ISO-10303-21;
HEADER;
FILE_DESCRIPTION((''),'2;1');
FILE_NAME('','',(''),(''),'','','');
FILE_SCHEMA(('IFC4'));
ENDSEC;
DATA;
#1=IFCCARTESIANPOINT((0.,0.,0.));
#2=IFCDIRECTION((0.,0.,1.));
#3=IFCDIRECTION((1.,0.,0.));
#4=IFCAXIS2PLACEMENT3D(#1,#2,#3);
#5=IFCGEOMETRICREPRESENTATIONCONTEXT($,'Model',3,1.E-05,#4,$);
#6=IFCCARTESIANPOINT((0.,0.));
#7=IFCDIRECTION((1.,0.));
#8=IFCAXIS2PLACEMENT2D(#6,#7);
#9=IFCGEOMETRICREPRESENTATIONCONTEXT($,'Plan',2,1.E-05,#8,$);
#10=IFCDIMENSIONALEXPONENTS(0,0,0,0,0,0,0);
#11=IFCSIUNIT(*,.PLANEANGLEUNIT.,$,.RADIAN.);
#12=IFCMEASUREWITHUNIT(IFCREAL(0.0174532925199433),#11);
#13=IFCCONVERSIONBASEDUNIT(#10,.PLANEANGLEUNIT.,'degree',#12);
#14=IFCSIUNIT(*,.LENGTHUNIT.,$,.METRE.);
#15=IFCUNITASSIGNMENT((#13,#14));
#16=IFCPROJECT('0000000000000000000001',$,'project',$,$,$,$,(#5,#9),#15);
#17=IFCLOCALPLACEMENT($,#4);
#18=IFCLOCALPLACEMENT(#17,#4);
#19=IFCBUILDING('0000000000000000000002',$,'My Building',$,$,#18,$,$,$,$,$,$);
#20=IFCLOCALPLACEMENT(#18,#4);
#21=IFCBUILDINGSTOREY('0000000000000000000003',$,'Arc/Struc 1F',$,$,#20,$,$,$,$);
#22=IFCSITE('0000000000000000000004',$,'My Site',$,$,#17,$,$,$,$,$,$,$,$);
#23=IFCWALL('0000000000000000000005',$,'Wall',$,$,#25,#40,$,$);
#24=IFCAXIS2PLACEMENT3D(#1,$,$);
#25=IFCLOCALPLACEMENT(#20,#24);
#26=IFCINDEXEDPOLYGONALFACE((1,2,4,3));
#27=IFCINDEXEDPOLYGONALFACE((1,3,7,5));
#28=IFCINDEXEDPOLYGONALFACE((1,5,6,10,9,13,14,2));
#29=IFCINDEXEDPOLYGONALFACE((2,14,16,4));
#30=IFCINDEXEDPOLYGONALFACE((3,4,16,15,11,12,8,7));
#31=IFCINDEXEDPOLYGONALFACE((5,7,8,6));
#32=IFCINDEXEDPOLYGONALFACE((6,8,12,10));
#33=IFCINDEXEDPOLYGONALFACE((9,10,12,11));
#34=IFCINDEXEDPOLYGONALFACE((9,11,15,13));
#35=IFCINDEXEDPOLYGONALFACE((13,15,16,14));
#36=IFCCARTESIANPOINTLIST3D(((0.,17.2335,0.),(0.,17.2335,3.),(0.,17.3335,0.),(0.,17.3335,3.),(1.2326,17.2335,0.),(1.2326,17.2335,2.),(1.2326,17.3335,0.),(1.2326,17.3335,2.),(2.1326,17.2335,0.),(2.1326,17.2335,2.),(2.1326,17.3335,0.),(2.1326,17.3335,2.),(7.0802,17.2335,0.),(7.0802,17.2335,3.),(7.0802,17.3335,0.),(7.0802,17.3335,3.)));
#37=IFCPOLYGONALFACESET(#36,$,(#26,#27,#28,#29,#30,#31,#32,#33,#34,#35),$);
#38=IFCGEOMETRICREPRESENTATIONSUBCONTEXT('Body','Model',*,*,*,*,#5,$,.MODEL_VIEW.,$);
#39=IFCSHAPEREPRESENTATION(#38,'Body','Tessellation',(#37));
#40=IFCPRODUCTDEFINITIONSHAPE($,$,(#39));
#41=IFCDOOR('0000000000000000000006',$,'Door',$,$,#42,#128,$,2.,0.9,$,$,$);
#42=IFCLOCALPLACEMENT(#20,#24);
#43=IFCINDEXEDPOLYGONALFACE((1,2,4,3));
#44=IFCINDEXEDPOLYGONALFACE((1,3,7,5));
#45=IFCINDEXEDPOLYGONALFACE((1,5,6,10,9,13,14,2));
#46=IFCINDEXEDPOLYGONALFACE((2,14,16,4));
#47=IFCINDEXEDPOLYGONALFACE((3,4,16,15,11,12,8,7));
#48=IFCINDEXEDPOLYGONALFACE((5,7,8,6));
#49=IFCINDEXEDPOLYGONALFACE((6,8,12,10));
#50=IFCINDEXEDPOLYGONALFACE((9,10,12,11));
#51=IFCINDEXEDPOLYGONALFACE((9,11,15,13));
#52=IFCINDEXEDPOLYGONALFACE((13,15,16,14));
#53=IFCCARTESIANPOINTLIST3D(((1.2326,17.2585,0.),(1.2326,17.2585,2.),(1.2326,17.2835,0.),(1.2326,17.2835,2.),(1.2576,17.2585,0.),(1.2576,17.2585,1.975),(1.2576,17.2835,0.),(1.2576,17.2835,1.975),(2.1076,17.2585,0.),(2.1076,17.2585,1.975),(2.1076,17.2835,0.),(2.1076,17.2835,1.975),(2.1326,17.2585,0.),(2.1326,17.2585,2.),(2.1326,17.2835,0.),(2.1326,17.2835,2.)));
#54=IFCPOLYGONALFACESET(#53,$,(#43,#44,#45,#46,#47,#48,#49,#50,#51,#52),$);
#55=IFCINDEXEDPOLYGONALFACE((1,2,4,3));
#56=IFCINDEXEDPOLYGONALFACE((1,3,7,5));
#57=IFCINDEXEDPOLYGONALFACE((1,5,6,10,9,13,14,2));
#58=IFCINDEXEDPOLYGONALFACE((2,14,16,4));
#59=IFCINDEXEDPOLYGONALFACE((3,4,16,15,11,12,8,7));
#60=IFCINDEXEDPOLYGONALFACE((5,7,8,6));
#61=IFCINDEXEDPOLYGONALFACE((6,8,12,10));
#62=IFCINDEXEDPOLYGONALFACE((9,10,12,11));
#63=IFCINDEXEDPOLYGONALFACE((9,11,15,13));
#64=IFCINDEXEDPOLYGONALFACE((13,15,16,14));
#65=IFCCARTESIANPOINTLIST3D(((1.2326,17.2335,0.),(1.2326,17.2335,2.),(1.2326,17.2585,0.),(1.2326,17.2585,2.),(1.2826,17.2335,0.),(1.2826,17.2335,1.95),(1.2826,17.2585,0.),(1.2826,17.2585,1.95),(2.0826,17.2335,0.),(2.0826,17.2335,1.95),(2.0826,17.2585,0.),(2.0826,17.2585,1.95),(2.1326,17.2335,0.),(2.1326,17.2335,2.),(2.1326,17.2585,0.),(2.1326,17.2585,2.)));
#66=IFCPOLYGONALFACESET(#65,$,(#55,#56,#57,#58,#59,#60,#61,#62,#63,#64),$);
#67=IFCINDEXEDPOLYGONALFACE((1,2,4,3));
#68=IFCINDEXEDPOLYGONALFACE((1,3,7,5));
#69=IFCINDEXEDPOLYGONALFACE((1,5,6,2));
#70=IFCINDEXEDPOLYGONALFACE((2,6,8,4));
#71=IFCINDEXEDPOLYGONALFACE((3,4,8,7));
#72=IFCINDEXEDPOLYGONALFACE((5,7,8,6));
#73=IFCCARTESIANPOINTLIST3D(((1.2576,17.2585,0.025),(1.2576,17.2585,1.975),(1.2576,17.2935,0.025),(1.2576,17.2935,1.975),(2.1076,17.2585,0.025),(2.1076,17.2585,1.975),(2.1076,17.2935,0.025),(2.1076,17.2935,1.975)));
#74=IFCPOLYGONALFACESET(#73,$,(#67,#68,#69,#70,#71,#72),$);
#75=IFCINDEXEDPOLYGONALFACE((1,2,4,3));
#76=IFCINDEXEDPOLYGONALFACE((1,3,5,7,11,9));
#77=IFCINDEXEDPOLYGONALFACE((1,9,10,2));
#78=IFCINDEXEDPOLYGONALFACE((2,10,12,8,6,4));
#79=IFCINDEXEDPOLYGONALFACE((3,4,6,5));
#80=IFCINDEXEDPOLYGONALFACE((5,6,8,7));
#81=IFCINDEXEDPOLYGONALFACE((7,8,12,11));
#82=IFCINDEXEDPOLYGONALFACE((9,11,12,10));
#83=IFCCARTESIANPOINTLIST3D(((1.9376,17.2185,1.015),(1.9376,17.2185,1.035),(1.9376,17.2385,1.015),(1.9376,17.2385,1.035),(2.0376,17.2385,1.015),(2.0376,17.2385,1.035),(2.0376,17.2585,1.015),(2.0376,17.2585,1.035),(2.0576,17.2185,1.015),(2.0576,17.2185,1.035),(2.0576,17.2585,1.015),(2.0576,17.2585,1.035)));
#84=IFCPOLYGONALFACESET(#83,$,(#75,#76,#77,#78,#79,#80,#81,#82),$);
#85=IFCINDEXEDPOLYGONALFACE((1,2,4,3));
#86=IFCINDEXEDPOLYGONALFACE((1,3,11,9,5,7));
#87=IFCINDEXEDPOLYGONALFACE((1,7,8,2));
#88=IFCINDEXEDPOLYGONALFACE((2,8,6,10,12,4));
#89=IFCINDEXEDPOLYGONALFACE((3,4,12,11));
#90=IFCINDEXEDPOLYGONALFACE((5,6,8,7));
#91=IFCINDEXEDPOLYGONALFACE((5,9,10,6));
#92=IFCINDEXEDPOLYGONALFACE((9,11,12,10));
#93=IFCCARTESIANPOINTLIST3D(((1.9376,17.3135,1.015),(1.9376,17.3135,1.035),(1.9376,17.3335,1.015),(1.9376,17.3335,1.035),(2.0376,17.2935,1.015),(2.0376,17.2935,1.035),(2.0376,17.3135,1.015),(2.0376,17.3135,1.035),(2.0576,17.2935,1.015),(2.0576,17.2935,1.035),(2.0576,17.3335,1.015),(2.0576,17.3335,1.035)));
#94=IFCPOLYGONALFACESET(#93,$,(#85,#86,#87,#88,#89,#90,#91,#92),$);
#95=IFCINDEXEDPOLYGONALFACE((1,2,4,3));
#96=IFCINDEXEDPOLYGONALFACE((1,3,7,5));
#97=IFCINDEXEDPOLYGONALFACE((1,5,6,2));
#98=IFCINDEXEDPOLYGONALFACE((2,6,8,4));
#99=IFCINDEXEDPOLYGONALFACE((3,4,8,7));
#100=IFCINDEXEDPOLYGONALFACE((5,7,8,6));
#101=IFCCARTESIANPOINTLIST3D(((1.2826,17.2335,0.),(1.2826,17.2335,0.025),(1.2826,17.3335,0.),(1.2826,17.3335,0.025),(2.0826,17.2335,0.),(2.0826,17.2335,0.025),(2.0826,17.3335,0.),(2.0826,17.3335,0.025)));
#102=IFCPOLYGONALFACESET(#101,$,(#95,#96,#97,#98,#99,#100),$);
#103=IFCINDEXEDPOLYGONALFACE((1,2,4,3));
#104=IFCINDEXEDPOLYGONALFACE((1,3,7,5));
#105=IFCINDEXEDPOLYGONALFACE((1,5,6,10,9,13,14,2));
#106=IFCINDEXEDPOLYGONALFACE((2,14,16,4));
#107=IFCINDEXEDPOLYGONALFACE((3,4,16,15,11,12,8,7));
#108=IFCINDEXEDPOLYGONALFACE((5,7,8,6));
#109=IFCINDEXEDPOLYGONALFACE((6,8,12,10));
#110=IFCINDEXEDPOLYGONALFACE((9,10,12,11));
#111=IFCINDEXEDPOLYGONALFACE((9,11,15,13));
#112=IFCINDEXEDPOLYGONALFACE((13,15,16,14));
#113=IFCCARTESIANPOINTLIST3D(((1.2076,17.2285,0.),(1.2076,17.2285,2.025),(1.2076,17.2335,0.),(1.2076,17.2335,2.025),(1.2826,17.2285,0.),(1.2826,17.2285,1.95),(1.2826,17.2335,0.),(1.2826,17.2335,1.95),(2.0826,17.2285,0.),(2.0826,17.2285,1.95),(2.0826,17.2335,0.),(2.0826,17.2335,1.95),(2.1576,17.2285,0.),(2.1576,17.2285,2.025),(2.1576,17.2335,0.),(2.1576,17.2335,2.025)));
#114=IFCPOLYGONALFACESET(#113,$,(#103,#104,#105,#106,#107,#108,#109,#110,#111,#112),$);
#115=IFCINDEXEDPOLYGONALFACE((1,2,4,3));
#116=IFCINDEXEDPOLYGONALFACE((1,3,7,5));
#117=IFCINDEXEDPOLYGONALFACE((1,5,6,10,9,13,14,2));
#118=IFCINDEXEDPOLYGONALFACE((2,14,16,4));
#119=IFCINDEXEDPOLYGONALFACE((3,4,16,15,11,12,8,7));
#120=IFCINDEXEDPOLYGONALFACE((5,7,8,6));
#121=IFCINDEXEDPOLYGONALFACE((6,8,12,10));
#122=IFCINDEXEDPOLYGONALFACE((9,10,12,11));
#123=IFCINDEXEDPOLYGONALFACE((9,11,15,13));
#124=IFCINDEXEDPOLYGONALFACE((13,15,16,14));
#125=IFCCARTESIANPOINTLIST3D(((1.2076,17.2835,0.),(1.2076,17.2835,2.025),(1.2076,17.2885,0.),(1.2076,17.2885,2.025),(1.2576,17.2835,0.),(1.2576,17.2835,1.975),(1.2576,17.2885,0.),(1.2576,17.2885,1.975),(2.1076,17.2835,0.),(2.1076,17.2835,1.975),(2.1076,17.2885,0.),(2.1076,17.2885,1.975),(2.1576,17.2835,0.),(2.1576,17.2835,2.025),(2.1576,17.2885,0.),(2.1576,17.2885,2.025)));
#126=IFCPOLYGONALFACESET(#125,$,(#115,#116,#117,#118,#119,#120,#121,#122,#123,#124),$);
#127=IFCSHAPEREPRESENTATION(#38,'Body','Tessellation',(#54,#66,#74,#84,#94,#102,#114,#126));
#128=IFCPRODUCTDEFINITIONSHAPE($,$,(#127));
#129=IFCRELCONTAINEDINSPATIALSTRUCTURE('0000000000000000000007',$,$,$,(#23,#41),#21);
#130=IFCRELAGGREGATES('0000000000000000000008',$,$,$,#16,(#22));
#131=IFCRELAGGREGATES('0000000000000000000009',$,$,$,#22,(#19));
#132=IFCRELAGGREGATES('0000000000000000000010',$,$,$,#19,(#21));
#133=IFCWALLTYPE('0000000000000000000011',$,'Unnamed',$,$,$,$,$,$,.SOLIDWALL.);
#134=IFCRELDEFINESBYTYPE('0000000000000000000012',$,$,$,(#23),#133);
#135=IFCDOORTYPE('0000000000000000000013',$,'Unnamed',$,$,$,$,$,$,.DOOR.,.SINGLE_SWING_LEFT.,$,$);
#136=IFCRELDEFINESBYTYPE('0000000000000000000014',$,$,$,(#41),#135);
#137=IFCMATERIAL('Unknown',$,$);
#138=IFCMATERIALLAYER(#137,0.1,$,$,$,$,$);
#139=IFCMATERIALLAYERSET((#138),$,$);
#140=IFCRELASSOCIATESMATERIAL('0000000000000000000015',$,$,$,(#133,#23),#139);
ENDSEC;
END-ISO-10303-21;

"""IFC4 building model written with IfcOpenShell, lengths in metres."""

from ifc_helpers import new_model, entity, si_unit, converted_unit, frame, origin_with_axes, origin_2d_with_axis, place, context, subcontext, project, spatial, line, indexed_curve, outline, extrude, shape, source, transform, mapped, material, layer, layer_set, layer_usage, type_object, type_shapes, element, fill, save


model = new_model("IFC4")

# Units and contexts
model_context = context("Model", 3, precision=1e-05, world=origin_with_axes())
plan_context = context("Plan", 2, precision=1e-05, world=origin_2d_with_axis())
body_context_1 = subcontext(model_context, "Body", "Model", "MODEL_VIEW")
body_context_2 = subcontext(plan_context, "Body", "Plan", "PLAN_VIEW")
ifc_project = project(units=[converted_unit("PLANEANGLEUNIT", "degree", entity("IfcReal", 0.0174532925199433), si_unit("PLANEANGLEUNIT", "RADIAN"), dimensions=[0, 0, 0, 0, 0, 0, 0]), si_unit("LENGTHUNIT", "METRE")], contexts=[model_context, plan_context])

# Site, building, storey
site_placement = place(None, origin_with_axes())
site = spatial("IfcSite", under=ifc_project, at=site_placement, Name="My Site")
building_placement = place(site_placement, origin_with_axes())
building = spatial("IfcBuilding", under=site, at=building_placement, Name="My Building")
storey_placement = place(building_placement, origin_with_axes())
storey = spatial("IfcBuildingStorey", under=building, at=storey_placement, Name="Arc/Struc 1F")

# Shared definitions
ifc_material = material(Name="Unknown")

# Shared definitions
ifc_layer_1 = layer(ifc_material, 0.1)
ifc_layer_set_1 = layer_set([ifc_layer_1])
wall_type = type_object("IfcWallType", Name="Unnamed", PredefinedType="SOLIDWALL", material=ifc_layer_set_1)

# Shared definitions
shared_shape_1 = source(origin_with_axes(), body_context_1, "Body", "SweptSolid", [
    extrude(outline(indexed_curve([(0.0, 0.0), (0.9, 0.0), (0.9, 2.0), (0.0, 2.0)], segments=[line(1, 2, 3, 4, 1)])), frame((0.0, -0.6, 0.0), z_axis=(0.0, -1.0, 0.0), x_axis=(1.0, 0.0, 0.0)), (0.0, 0.0, -1.0), 1.2),
])
door_type = type_object("IfcDoorType", Name="Unnamed", OperationType="SINGLE_SWING_LEFT", PredefinedType="DOOR")
shared_shape_2 = source(origin_with_axes(), body_context_1, "Body", "SweptSolid", [
    extrude(outline(indexed_curve([(0.0, 0.0), (0.0, 2.0), (0.9, 2.0), (0.9, 0.0), (0.875, 0.0), (0.875, 1.975), (0.025, 1.975), (0.025, 0.0)], segments=[line(1, 2, 3, 4, 5, 6, 7, 8, 1)])), frame((0.0, 0.025, 0.0), z_axis=(0.0, -1.0, 0.0), x_axis=(1.0, 0.0, 0.0)), (0.0, 0.0, -1.0), 0.025),
    extrude(outline(indexed_curve([(0.0, 0.0), (0.0, 2.0), (0.9, 2.0), (0.9, 0.0), (0.85, 0.0), (0.85, 1.95), (0.05, 1.95), (0.05, 0.0)], segments=[line(1, 2, 3, 4, 5, 6, 7, 8, 1)])), frame((0.0, 0.0, 0.0), z_axis=(0.0, -1.0, 0.0), x_axis=(1.0, 0.0, 0.0)), (0.0, 0.0, -1.0), 0.025),
    extrude(outline(indexed_curve([(0.0, 0.0), (0.85, 0.0), (0.85, 0.035), (0.0, 0.035)], segments=[line(1, 2, 3, 4, 1)])), frame((0.025, 0.025, 0.025), z_axis=(0.0, 0.0, 1.0), x_axis=(1.0, 0.0, 0.0)), (0.0, 0.0, 1.0), 1.95),
    extrude(outline(indexed_curve([(0.0, 0.0), (0.0, -0.04), (-0.12, -0.04), (-0.12, -0.02), (-0.02, -0.02), (-0.02, 0.0)], segments=[line(1, 2, 3, 4, 5, 6, 1)])), frame((0.825, 0.025, 1.015), z_axis=(0.0, 0.0, 1.0), x_axis=(1.0, 0.0, 0.0)), (0.0, 0.0, 1.0), 0.02),
    extrude(outline(indexed_curve([(0.0, 0.0), (0.0, 0.04), (-0.12, 0.04), (-0.12, 0.02), (-0.02, 0.02), (-0.02, 0.0)], segments=[line(1, 2, 3, 4, 5, 6, 1)])), frame((0.825, 0.06, 1.015), z_axis=(0.0, 0.0, 1.0), x_axis=(1.0, 0.0, 0.0)), (0.0, 0.0, 1.0), 0.02),
    extrude(outline(indexed_curve([(0.0, 0.0), (0.8, 0.0), (0.8, 0.1), (0.0, 0.1)], segments=[line(1, 2, 3, 4, 1)])), frame((0.05, 0.0, 0.0), z_axis=(0.0, 0.0, 1.0), x_axis=(1.0, 0.0, 0.0)), (0.0, 0.0, 1.0), 0.025),
    extrude(outline(indexed_curve([(0.0, 0.0), (0.0, 2.025), (0.95, 2.025), (0.95, 0.0), (0.875, 0.0), (0.875, 1.95), (0.075, 1.95), (0.075, 0.0)], segments=[line(1, 2, 3, 4, 5, 6, 7, 8, 1)])), frame((-0.025, -0.005, 0.0), z_axis=(0.0, -1.0, 0.0), x_axis=(1.0, 0.0, 0.0)), (0.0, 0.0, -1.0), 0.005),
    extrude(outline(indexed_curve([(0.0, 0.0), (0.0, 2.025), (0.95, 2.025), (0.95, 0.0), (0.9, 0.0), (0.9, 1.975), (0.05, 1.975), (0.05, 0.0)], segments=[line(1, 2, 3, 4, 5, 6, 7, 8, 1)])), frame((-0.025, 0.05, 0.0), z_axis=(0.0, -1.0, 0.0), x_axis=(1.0, 0.0, 0.0)), (0.0, 0.0, -1.0), 0.005),
])
shared_shape_3 = source(origin_with_axes(), body_context_2, "Body", "Curve2D", [
    entity("IfcIndexedPolyCurve", entity("IfcCartesianPointList2D", [[0.0, 0.0], [0.0, 0.05], [0.025, 0.05], [0.025, 0.025], [0.05, 0.025], [0.05, 0.0]]), [entity("IfcLineIndex", [1, 2, 3, 4, 5, 6, 1])]),
    entity("IfcIndexedPolyCurve", entity("IfcCartesianPointList2D", [[0.9, 0.0], [0.9, 0.05], [0.875, 0.05], [0.875, 0.025], [0.85, 0.025], [0.85, 0.0]]), [entity("IfcLineIndex", [1, 2, 3, 4, 5, 6, 1])]),
    entity("IfcTrimmedCurve", entity("IfcEllipse", entity("IfcAxis2Placement2D", entity("IfcCartesianPoint", [0.06, 0.05]), entity("IfcDirection", [1.0, 0.0])), 0.815, 0.85), [entity("IfcCartesianPoint", [0.875, 0.05])], [entity("IfcCartesianPoint", [0.06, 0.9])], True, "CARTESIAN"),
    entity("IfcIndexedPolyCurve", entity("IfcCartesianPointList2D", [[0.025, 0.05], [0.06, 0.05], [0.06, 0.9], [0.025, 0.9]]), [entity("IfcLineIndex", [1, 2, 3, 4, 1])]),
])
type_shapes(door_type, [shared_shape_2, shared_shape_3])

# Wall, opening, door
ifc_layer_usage_1 = layer_usage(ifc_layer_set_1, "AXIS2", "POSITIVE", 0.0)
wall_1_placement = place(storey_placement, frame((0.0, 17.2335, 0.0), z_axis=(0.0, 0.0, 1.0), x_axis=(1.0, 0.0, 0.0)))
wall_1 = element("IfcWall", 1, at=wall_1_placement, inside=storey, type_object=wall_type, material=ifc_layer_usage_1, Name="Wall", context=body_context_1, shape_type="SweptSolid", body=[
    extrude(outline(indexed_curve([(0.0, 0.0), (0.0, 0.1), (7.0802, 0.1), (7.0802, 0.0)], segments=[line(1, 2, 3, 4, 1)])), origin_with_axes(), (0.0, 0.0, 1.0), 3.0),
])
opening_1_placement = place(wall_1_placement, frame((1.2326, 0.0, 0.0), z_axis=(0.0, 0.0, 1.0), x_axis=(1.0, 0.0, 0.0)))
opening_1 = element("IfcOpeningElement", 2, at=opening_1_placement, cuts=wall_1, PredefinedType="OPENING", context=body_context_1, shape_type="MappedRepresentation", body=[
    mapped(shared_shape_1, transform((0.0, 0.0, 0.0), x_axis=(1.0, 0.0, 0.0), y_axis=(0.0, 1.0, 0.0), z_axis=(0.0, 0.0, 1.0), scale=1.0)),
])
door_1_placement = place(opening_1_placement, origin_with_axes())
door_1 = element("IfcDoor", 3, at=door_1_placement, inside=storey, type_object=door_type, Name="Door", OverallHeight=2.0, OverallWidth=0.9, shapes=[
    shape(body_context_1, "Body", "MappedRepresentation", [mapped(shared_shape_2, transform((0.0, 0.0, 0.0), x_axis=(1.0, 0.0, 0.0), y_axis=(0.0, 1.0, 0.0), z_axis=(0.0, 0.0, 1.0), scale=1.0))]),
    shape(body_context_2, "Body", "MappedRepresentation", [mapped(shared_shape_3, transform((0.0, 0.0, 0.0), x_axis=(1.0, 0.0, 0.0), y_axis=(0.0, 1.0, 0.0), z_axis=(0.0, 0.0, 1.0), scale=1.0))]),
])
fill(opening_1, door_1)

save(model, "model.ifc")
